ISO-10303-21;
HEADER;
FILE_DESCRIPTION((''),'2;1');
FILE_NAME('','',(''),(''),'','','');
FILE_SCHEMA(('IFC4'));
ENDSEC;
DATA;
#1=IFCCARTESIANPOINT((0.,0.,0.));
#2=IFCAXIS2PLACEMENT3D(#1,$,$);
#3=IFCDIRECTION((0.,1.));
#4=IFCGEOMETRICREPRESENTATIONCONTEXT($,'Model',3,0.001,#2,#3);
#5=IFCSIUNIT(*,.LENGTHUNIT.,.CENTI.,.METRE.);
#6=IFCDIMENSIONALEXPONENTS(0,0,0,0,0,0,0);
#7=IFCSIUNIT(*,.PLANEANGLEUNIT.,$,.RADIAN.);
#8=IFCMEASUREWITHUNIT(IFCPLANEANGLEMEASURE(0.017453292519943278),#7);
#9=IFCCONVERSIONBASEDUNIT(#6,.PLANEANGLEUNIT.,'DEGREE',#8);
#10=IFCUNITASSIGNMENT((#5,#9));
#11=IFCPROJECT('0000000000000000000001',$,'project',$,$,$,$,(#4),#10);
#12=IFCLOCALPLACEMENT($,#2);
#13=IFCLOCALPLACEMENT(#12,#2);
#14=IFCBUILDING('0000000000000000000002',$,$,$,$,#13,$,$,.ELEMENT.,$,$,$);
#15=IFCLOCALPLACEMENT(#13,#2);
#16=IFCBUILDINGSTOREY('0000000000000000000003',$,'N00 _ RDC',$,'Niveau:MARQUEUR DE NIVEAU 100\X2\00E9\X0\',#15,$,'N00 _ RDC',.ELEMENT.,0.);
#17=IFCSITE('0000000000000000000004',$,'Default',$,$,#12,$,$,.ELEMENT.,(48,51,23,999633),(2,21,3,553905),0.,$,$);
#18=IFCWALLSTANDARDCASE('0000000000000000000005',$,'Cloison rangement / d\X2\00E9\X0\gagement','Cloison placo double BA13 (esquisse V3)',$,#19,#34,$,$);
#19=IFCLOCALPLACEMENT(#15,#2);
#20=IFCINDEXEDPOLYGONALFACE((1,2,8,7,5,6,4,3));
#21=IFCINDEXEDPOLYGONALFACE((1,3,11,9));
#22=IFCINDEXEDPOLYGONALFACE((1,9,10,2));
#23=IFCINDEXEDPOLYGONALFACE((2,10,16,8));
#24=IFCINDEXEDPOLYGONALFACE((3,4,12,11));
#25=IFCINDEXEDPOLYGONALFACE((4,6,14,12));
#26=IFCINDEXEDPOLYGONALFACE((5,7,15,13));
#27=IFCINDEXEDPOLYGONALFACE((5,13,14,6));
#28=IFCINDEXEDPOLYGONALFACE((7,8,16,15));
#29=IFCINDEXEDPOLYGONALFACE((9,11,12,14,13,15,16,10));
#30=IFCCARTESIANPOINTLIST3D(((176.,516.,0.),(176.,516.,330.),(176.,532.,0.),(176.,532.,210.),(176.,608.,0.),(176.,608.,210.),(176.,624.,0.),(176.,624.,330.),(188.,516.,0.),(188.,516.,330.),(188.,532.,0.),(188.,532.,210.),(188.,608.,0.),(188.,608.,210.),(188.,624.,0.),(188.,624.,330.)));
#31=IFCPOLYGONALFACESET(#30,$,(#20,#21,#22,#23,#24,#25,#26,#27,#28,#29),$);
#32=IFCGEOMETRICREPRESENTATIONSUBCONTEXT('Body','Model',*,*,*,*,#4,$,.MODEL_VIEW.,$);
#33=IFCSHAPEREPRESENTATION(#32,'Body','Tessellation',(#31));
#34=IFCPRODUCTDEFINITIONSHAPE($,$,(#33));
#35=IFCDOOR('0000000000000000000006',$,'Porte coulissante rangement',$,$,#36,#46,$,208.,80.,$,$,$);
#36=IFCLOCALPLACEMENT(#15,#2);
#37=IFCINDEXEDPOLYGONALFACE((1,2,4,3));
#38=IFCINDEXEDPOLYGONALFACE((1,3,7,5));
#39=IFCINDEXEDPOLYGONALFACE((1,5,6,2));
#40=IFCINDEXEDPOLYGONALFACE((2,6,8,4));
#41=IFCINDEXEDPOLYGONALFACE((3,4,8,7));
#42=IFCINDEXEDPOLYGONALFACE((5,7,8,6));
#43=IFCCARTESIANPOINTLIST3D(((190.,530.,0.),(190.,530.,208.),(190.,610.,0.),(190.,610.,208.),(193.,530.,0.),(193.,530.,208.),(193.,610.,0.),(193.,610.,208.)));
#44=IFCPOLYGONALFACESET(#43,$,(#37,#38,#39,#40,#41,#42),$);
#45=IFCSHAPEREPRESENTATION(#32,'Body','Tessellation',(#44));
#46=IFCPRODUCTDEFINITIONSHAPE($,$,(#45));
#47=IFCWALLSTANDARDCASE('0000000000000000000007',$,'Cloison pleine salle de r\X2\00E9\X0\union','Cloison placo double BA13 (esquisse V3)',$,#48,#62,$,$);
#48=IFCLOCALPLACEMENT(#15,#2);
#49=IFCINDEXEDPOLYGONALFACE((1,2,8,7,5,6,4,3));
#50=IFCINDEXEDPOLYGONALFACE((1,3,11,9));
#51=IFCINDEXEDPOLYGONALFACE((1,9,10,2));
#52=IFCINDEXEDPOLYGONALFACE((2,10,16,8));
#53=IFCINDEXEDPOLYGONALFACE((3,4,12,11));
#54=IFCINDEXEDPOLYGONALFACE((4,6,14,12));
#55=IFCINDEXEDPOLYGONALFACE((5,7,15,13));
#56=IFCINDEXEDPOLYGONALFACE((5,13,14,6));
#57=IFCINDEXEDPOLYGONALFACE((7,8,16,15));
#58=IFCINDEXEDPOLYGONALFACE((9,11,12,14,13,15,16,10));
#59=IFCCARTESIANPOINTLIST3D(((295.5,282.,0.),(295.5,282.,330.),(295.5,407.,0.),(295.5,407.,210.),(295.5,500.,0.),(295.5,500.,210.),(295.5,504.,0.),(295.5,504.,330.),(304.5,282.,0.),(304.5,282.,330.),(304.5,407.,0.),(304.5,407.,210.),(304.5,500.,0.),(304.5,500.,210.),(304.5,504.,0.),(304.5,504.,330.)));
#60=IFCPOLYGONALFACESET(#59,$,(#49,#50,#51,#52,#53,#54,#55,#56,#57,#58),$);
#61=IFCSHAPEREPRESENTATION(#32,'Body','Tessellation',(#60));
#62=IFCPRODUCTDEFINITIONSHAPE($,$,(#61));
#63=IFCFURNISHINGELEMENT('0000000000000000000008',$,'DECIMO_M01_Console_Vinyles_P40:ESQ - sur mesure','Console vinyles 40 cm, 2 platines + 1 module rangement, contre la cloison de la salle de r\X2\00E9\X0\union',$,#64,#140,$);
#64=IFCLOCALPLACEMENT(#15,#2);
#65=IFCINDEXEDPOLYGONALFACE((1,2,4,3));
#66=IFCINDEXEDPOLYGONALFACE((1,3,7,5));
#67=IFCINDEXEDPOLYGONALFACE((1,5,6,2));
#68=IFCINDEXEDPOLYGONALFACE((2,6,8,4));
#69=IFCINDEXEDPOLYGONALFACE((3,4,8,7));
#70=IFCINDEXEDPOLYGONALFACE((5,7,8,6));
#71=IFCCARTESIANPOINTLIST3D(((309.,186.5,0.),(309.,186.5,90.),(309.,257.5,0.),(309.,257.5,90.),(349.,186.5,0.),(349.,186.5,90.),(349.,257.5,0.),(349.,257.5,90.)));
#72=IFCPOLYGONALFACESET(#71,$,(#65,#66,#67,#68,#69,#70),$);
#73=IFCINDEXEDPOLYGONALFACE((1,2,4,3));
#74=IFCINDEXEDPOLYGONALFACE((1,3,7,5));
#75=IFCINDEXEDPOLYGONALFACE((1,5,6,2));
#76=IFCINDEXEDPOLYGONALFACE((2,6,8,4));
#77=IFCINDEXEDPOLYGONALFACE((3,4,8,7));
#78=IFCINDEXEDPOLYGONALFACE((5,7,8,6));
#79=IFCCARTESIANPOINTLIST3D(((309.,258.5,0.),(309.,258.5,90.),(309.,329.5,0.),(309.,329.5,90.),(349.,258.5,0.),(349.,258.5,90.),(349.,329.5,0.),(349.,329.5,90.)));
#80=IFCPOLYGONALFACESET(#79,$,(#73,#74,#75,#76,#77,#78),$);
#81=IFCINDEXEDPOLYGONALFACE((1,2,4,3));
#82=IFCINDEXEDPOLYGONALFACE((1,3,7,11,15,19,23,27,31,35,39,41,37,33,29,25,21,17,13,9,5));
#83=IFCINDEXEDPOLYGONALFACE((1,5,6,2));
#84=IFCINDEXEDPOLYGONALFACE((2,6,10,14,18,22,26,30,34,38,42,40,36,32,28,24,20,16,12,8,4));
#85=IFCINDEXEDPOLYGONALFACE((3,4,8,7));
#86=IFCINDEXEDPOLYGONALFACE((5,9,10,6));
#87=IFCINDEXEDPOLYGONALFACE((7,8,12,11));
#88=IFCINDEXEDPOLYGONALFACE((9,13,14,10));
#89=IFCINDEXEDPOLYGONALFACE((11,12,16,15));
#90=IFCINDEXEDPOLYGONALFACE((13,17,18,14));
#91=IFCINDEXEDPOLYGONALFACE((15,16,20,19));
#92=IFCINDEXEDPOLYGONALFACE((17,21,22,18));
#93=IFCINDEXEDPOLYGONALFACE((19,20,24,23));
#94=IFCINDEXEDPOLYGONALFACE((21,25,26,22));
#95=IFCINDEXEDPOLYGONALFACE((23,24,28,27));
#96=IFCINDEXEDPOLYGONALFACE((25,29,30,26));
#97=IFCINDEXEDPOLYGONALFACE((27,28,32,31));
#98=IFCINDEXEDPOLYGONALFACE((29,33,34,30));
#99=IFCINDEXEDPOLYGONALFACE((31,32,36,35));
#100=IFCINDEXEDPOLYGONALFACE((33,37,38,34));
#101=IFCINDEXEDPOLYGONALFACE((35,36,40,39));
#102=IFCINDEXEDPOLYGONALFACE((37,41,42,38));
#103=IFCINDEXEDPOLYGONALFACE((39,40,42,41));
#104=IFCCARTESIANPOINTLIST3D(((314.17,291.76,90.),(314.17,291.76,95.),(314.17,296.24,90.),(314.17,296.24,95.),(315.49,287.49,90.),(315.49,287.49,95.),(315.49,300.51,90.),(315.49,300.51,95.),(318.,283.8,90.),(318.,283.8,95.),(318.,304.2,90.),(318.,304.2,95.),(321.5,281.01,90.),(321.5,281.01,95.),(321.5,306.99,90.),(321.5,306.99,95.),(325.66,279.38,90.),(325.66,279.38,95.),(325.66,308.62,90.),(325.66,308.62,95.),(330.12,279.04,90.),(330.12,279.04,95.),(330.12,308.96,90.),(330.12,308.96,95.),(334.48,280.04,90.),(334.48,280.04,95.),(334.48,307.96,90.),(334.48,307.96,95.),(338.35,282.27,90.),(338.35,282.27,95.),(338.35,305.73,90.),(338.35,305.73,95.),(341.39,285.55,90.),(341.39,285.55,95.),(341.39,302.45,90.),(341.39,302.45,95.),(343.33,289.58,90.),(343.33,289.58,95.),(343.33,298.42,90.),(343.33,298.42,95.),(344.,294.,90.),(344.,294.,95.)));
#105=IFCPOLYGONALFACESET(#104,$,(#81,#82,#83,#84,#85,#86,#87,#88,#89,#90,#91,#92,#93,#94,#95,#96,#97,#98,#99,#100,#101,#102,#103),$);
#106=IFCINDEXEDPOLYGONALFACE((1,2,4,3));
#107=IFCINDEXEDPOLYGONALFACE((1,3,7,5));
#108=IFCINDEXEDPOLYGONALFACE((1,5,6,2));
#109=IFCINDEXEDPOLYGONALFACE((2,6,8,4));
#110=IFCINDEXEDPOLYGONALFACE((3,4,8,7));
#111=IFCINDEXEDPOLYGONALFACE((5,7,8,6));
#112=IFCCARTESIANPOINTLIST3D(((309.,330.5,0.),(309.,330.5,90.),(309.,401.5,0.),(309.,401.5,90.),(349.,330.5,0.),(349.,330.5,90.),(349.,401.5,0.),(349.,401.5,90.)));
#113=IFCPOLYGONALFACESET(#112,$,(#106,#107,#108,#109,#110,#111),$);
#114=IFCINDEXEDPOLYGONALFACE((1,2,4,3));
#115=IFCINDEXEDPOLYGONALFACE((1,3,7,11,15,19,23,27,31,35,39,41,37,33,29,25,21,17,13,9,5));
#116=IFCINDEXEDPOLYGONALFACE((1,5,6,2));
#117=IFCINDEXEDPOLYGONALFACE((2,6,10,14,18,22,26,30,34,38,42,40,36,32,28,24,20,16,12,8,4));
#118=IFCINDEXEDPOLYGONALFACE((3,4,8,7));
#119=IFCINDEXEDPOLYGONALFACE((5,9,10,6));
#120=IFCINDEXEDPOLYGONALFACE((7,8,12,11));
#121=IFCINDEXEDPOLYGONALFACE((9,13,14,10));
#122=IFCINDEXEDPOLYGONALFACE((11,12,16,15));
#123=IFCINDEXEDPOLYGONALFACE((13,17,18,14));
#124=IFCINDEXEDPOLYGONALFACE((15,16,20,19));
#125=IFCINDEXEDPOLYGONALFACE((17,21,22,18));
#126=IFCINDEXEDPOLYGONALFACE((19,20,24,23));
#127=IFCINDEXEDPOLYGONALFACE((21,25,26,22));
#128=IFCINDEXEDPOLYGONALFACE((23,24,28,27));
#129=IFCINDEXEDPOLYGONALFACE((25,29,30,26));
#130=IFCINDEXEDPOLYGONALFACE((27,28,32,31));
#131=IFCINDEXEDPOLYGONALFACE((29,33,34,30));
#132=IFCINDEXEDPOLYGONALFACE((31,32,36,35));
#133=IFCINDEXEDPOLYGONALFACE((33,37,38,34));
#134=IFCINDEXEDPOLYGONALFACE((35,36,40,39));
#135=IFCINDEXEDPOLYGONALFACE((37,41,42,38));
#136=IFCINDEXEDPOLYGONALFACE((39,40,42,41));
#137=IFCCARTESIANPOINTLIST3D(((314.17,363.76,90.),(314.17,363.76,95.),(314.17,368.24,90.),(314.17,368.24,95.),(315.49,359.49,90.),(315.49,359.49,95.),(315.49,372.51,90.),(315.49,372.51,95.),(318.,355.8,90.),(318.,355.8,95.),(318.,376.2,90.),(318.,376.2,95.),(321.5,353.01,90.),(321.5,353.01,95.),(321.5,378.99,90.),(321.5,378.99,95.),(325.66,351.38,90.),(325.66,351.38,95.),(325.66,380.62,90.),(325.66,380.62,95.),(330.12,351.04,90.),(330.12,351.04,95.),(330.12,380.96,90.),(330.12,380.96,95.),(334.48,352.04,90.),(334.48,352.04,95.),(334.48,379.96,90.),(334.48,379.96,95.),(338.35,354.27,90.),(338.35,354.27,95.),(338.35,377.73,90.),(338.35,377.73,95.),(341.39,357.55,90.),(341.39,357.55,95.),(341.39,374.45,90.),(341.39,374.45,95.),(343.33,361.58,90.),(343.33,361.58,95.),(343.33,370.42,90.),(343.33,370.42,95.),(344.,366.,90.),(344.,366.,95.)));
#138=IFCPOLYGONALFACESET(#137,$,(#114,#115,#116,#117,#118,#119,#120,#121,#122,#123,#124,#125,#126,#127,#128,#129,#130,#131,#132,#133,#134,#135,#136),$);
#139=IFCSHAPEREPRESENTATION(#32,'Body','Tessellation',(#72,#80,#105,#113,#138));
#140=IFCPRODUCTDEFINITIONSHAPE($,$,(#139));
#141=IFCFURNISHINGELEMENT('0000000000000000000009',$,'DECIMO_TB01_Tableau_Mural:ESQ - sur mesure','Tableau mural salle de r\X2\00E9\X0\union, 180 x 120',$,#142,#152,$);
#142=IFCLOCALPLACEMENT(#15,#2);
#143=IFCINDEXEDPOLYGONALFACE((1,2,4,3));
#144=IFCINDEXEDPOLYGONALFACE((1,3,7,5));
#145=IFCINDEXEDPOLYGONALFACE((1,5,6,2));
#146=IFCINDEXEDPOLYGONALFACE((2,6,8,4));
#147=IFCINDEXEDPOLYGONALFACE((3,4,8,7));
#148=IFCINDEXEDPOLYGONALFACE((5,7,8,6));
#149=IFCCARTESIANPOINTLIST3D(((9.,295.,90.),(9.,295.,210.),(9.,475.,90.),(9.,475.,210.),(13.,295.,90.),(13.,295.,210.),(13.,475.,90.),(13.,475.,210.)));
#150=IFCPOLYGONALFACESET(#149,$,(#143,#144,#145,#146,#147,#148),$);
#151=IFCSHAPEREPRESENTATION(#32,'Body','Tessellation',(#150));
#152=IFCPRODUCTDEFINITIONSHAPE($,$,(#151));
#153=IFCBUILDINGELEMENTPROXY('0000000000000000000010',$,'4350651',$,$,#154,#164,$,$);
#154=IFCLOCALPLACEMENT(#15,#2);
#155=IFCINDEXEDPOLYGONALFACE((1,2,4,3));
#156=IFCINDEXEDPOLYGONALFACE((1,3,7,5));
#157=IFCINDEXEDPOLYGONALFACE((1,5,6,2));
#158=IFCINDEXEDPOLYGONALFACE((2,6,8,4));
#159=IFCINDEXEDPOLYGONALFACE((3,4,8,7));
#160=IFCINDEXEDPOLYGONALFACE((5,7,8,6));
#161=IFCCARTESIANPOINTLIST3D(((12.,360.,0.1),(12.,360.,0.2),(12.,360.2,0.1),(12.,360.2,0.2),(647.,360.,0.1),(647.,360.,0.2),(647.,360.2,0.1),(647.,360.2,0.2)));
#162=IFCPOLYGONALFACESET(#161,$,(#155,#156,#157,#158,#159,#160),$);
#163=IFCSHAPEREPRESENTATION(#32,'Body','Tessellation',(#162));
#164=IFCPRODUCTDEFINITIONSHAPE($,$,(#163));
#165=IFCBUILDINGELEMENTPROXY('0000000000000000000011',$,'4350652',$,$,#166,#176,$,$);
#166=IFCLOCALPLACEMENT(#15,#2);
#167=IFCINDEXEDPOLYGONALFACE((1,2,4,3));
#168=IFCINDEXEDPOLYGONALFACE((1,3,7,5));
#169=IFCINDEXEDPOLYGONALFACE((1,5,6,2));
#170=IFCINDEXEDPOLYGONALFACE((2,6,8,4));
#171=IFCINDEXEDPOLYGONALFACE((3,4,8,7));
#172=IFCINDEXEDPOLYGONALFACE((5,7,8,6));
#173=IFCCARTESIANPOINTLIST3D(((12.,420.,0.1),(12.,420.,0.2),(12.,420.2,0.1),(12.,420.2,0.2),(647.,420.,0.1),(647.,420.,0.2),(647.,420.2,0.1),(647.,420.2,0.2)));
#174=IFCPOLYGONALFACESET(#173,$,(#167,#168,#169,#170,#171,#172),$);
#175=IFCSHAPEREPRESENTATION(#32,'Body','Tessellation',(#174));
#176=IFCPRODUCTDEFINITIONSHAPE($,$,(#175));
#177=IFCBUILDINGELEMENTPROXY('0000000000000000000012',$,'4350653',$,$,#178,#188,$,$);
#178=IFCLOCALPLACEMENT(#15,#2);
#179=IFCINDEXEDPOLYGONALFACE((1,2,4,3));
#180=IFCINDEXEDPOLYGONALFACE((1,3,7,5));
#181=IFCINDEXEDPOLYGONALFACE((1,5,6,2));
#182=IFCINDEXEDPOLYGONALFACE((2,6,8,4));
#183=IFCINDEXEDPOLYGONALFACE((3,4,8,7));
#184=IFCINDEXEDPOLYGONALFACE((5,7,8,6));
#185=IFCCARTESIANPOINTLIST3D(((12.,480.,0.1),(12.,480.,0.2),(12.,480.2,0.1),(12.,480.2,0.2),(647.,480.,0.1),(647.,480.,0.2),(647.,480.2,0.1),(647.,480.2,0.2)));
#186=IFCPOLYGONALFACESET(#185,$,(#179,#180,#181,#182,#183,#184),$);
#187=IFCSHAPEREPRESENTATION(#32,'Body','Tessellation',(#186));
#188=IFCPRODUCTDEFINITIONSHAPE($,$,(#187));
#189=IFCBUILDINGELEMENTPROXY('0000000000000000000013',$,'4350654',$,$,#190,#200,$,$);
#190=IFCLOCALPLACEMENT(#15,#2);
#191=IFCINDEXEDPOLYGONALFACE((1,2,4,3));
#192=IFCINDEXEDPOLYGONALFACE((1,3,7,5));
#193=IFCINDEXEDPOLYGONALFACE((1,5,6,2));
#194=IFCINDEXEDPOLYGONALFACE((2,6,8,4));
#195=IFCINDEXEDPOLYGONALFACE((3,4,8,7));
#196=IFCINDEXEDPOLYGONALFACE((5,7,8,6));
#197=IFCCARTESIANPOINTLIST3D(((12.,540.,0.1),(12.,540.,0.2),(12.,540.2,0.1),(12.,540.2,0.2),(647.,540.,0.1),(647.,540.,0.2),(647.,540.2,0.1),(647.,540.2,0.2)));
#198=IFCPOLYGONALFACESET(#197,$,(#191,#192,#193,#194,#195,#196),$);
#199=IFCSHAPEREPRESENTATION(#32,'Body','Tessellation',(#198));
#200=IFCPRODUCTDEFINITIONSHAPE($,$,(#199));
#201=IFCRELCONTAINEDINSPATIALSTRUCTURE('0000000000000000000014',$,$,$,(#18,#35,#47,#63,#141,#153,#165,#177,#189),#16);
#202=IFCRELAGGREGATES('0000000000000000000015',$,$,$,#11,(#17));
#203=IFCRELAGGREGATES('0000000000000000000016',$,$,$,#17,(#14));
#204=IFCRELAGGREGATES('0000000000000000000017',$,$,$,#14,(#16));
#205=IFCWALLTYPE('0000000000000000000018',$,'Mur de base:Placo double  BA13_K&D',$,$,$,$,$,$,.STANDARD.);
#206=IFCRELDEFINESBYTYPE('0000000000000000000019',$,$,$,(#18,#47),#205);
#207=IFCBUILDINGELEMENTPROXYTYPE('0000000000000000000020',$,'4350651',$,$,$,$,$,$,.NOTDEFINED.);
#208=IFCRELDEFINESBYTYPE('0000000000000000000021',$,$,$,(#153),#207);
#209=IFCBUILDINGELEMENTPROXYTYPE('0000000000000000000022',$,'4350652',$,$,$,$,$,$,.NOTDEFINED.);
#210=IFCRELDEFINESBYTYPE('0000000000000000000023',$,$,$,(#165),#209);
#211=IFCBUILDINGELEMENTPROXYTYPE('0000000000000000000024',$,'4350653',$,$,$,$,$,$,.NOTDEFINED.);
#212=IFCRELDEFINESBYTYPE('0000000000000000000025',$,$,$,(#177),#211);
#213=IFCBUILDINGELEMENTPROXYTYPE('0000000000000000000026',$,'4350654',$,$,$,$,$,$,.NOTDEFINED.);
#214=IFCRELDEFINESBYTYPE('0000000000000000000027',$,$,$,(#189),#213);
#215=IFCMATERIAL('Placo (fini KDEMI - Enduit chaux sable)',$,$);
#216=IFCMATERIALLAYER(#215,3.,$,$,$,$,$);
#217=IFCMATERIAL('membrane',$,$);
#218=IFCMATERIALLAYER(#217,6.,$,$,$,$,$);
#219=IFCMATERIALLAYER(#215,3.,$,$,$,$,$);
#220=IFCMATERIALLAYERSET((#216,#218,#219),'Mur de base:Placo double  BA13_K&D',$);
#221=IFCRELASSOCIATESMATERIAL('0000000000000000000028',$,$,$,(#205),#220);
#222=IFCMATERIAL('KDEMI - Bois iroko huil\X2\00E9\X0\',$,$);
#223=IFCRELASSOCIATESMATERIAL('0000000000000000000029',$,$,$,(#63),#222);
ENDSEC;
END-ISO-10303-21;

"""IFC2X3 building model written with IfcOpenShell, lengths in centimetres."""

from ifc_helpers import new_model, entity, si_unit, converted_unit, direction, frame, frame_2d, origin, origin_with_axes, place, context, subcontext, project, spatial, rectangle, circle, extrude, material, layer, layer_set, type_object, element, fill, save


model = new_model("IFC2X3")

# Units and contexts
model_context = context("Model", 3, precision=0.001, world=origin(), true_north=direction((0.0, 1.0)))
body_context = subcontext(model_context, "Body", "Model", "MODEL_VIEW")
ifc_project = project(units=[si_unit("LENGTHUNIT", "METRE", prefix="CENTI"), converted_unit("PLANEANGLEUNIT", "DEGREE", entity("IfcPlaneAngleMeasure", 0.017453292519943278), si_unit("PLANEANGLEUNIT", "RADIAN"), dimensions=[0, 0, 0, 0, 0, 0, 0])], contexts=[model_context])

# Site, building, storey
site_placement = place(None, origin())
site = spatial("IfcSite", under=ifc_project, at=site_placement, Name="Default", CompositionType="ELEMENT", RefLatitude=(48, 51, 23, 999633), RefLongitude=(2, 21, 3, 553905), RefElevation=0.0)
building_placement = place(site_placement, origin())
building = spatial("IfcBuilding", under=site, at=building_placement, CompositionType="ELEMENT")
storey_placement = place(building_placement, origin())
storey = spatial("IfcBuildingStorey", under=building, at=storey_placement, Name="N00 _ RDC", ObjectType="Niveau:MARQUEUR DE NIVEAU 100é", LongName="N00 _ RDC", CompositionType="ELEMENT", Elevation=0.0)

# Wall, opening, door
ifc_material_1 = material(Name="Placo (fini KDEMI - Enduit chaux sable)")
ifc_layer_1 = layer(ifc_material_1, 3.0)
ifc_material_2 = material(Name="membrane")
ifc_layer_2 = layer(ifc_material_2, 6.0)
ifc_layer_3 = layer(ifc_material_1, 3.0)
ifc_layer_set = layer_set([ifc_layer_1, ifc_layer_2, ifc_layer_3], Name="Mur de base:Placo double  BA13_K&D")
wall_type = type_object("IfcWallType", Name="Mur de base:Placo double  BA13_K&D", PredefinedType="STANDARD", material=ifc_layer_set)
wall_1_placement = place(storey_placement, origin_with_axes())
wall_1 = element("IfcWallStandardCase", 1, at=wall_1_placement, inside=storey, type_object=wall_type, Name="Cloison rangement / dégagement", Description="Cloison placo double BA13 (esquisse V3)", context=body_context, shape_type="SweptSolid", body=[
    extrude(rectangle(XDim=12.0, YDim=108.0, at=frame_2d((182.0, 570.0))), origin(), (0.0, 0.0, 1.0), 330.0),
])
opening_1_placement = place(wall_1_placement, origin_with_axes())
opening_1 = element("IfcOpeningElement", 2, at=opening_1_placement, inside=storey, cuts=wall_1, context=body_context, shape_type="SweptSolid", body=[
    extrude(rectangle(XDim=16.0, YDim=76.0, at=frame_2d((182.0, 570.0))), origin(), (0.0, 0.0, 1.0), 210.0),
])
door_placement = place(storey_placement, origin_with_axes())
door = element("IfcDoor", 3, at=door_placement, inside=storey, Name="Porte coulissante rangement", OverallHeight=208.0, OverallWidth=80.0, context=body_context, shape_type="SweptSolid", body=[
    extrude(rectangle(XDim=3.0, YDim=80.0, at=frame_2d((191.5, 570.0))), origin(), (0.0, 0.0, 1.0), 208.0),
])
fill(opening_1, door)

# Wall, opening
wall_2_placement = place(storey_placement, origin_with_axes())
wall_2 = element("IfcWallStandardCase", 4, at=wall_2_placement, inside=storey, type_object=wall_type, Name="Cloison pleine salle de réunion", Description="Cloison placo double BA13 (esquisse V3)", context=body_context, shape_type="SweptSolid", body=[
    extrude(rectangle(XDim=9.0, YDim=222.0, at=frame_2d((300.0, 393.0))), origin(), (0.0, 0.0, 1.0), 330.0),
])
opening_2_placement = place(wall_2_placement, origin_with_axes())
element("IfcOpeningElement", 5, at=opening_2_placement, inside=storey, cuts=wall_2, context=body_context, shape_type="SweptSolid", body=[
    extrude(rectangle(XDim=12.0, YDim=93.0, at=frame_2d((300.0, 453.5))), origin(), (0.0, 0.0, 1.0), 210.0),
])

# Furnishing elements
ifc_material_3 = material(Name="KDEMI - Bois iroko huilé")
furnishing_1_placement = place(storey_placement, origin_with_axes())
element("IfcFurnishingElement", 6, at=furnishing_1_placement, inside=storey, material=ifc_material_3, Name="DECIMO_M01_Console_Vinyles_P40:ESQ - sur mesure", Description="Console vinyles 40 cm, 2 platines + 1 module rangement, contre la cloison de la salle de réunion", context=body_context, shape_type="SweptSolid", body=[
    extrude(rectangle(XDim=40.0, YDim=71.0, at=frame_2d((329.0, 222.0))), origin(), (0.0, 0.0, 1.0), 90.0),
    extrude(rectangle(XDim=40.0, YDim=71.0, at=frame_2d((329.0, 294.0))), origin(), (0.0, 0.0, 1.0), 90.0),
    extrude(circle(Radius=15.0, at=frame_2d((329.0, 294.0))), frame((0.0, 0.0, 90.0)), (0.0, 0.0, 1.0), 5.0),
    extrude(rectangle(XDim=40.0, YDim=71.0, at=frame_2d((329.0, 366.0))), origin(), (0.0, 0.0, 1.0), 90.0),
    extrude(circle(Radius=15.0, at=frame_2d((329.0, 366.0))), frame((0.0, 0.0, 90.0)), (0.0, 0.0, 1.0), 5.0),
])
furnishing_2_placement = place(storey_placement, origin_with_axes())
element("IfcFurnishingElement", 7, at=furnishing_2_placement, inside=storey, Name="DECIMO_TB01_Tableau_Mural:ESQ - sur mesure", Description="Tableau mural salle de réunion, 180 x 120", context=body_context, shape_type="SweptSolid", body=[
    extrude(rectangle(XDim=4.0, YDim=180.0, at=frame_2d((11.0, 385.0))), frame((0.0, 0.0, 90.0)), (0.0, 0.0, 1.0), 120.0),
])

# Building element proxies
building_element_proxy_type_1 = type_object("IfcBuildingElementProxyType", Name="4350651", PredefinedType="NOTDEFINED")
proxy_1_placement = place(storey_placement, origin())
element("IfcBuildingElementProxy", 8, at=proxy_1_placement, inside=storey, type_object=building_element_proxy_type_1, Name="4350651", context=body_context, shape_type="SweptSolid", body=[
    extrude(rectangle(XDim=635.0, YDim=0.2, at=frame_2d((0.0, 0.0), x_axis=(1.0, 0.0))), frame((329.5, 360.1, 0.1)), (0.0, 0.0, 1.0), 0.1),
])
building_element_proxy_type_2 = type_object("IfcBuildingElementProxyType", Name="4350652", PredefinedType="NOTDEFINED")
proxy_2_placement = place(storey_placement, origin())
element("IfcBuildingElementProxy", 9, at=proxy_2_placement, inside=storey, type_object=building_element_proxy_type_2, Name="4350652", context=body_context, shape_type="SweptSolid", body=[
    extrude(rectangle(XDim=635.0, YDim=0.2, at=frame_2d((0.0, 0.0), x_axis=(1.0, 0.0))), frame((329.5, 420.1, 0.1)), (0.0, 0.0, 1.0), 0.1),
])
building_element_proxy_type_3 = type_object("IfcBuildingElementProxyType", Name="4350653", PredefinedType="NOTDEFINED")
proxy_3_placement = place(storey_placement, origin())
element("IfcBuildingElementProxy", 10, at=proxy_3_placement, inside=storey, type_object=building_element_proxy_type_3, Name="4350653", context=body_context, shape_type="SweptSolid", body=[
    extrude(rectangle(XDim=635.0, YDim=0.2, at=frame_2d((0.0, 0.0), x_axis=(1.0, 0.0))), frame((329.5, 480.1, 0.1)), (0.0, 0.0, 1.0), 0.1),
])
building_element_proxy_type_4 = type_object("IfcBuildingElementProxyType", Name="4350654", PredefinedType="NOTDEFINED")
proxy_4_placement = place(storey_placement, origin())
element("IfcBuildingElementProxy", 11, at=proxy_4_placement, inside=storey, type_object=building_element_proxy_type_4, Name="4350654", context=body_context, shape_type="SweptSolid", body=[
    extrude(rectangle(XDim=635.0, YDim=0.2, at=frame_2d((0.0, 0.0), x_axis=(1.0, 0.0))), frame((329.5, 540.1, 0.1)), (0.0, 0.0, 1.0), 0.1),
])

save(model, "model.ifc")
